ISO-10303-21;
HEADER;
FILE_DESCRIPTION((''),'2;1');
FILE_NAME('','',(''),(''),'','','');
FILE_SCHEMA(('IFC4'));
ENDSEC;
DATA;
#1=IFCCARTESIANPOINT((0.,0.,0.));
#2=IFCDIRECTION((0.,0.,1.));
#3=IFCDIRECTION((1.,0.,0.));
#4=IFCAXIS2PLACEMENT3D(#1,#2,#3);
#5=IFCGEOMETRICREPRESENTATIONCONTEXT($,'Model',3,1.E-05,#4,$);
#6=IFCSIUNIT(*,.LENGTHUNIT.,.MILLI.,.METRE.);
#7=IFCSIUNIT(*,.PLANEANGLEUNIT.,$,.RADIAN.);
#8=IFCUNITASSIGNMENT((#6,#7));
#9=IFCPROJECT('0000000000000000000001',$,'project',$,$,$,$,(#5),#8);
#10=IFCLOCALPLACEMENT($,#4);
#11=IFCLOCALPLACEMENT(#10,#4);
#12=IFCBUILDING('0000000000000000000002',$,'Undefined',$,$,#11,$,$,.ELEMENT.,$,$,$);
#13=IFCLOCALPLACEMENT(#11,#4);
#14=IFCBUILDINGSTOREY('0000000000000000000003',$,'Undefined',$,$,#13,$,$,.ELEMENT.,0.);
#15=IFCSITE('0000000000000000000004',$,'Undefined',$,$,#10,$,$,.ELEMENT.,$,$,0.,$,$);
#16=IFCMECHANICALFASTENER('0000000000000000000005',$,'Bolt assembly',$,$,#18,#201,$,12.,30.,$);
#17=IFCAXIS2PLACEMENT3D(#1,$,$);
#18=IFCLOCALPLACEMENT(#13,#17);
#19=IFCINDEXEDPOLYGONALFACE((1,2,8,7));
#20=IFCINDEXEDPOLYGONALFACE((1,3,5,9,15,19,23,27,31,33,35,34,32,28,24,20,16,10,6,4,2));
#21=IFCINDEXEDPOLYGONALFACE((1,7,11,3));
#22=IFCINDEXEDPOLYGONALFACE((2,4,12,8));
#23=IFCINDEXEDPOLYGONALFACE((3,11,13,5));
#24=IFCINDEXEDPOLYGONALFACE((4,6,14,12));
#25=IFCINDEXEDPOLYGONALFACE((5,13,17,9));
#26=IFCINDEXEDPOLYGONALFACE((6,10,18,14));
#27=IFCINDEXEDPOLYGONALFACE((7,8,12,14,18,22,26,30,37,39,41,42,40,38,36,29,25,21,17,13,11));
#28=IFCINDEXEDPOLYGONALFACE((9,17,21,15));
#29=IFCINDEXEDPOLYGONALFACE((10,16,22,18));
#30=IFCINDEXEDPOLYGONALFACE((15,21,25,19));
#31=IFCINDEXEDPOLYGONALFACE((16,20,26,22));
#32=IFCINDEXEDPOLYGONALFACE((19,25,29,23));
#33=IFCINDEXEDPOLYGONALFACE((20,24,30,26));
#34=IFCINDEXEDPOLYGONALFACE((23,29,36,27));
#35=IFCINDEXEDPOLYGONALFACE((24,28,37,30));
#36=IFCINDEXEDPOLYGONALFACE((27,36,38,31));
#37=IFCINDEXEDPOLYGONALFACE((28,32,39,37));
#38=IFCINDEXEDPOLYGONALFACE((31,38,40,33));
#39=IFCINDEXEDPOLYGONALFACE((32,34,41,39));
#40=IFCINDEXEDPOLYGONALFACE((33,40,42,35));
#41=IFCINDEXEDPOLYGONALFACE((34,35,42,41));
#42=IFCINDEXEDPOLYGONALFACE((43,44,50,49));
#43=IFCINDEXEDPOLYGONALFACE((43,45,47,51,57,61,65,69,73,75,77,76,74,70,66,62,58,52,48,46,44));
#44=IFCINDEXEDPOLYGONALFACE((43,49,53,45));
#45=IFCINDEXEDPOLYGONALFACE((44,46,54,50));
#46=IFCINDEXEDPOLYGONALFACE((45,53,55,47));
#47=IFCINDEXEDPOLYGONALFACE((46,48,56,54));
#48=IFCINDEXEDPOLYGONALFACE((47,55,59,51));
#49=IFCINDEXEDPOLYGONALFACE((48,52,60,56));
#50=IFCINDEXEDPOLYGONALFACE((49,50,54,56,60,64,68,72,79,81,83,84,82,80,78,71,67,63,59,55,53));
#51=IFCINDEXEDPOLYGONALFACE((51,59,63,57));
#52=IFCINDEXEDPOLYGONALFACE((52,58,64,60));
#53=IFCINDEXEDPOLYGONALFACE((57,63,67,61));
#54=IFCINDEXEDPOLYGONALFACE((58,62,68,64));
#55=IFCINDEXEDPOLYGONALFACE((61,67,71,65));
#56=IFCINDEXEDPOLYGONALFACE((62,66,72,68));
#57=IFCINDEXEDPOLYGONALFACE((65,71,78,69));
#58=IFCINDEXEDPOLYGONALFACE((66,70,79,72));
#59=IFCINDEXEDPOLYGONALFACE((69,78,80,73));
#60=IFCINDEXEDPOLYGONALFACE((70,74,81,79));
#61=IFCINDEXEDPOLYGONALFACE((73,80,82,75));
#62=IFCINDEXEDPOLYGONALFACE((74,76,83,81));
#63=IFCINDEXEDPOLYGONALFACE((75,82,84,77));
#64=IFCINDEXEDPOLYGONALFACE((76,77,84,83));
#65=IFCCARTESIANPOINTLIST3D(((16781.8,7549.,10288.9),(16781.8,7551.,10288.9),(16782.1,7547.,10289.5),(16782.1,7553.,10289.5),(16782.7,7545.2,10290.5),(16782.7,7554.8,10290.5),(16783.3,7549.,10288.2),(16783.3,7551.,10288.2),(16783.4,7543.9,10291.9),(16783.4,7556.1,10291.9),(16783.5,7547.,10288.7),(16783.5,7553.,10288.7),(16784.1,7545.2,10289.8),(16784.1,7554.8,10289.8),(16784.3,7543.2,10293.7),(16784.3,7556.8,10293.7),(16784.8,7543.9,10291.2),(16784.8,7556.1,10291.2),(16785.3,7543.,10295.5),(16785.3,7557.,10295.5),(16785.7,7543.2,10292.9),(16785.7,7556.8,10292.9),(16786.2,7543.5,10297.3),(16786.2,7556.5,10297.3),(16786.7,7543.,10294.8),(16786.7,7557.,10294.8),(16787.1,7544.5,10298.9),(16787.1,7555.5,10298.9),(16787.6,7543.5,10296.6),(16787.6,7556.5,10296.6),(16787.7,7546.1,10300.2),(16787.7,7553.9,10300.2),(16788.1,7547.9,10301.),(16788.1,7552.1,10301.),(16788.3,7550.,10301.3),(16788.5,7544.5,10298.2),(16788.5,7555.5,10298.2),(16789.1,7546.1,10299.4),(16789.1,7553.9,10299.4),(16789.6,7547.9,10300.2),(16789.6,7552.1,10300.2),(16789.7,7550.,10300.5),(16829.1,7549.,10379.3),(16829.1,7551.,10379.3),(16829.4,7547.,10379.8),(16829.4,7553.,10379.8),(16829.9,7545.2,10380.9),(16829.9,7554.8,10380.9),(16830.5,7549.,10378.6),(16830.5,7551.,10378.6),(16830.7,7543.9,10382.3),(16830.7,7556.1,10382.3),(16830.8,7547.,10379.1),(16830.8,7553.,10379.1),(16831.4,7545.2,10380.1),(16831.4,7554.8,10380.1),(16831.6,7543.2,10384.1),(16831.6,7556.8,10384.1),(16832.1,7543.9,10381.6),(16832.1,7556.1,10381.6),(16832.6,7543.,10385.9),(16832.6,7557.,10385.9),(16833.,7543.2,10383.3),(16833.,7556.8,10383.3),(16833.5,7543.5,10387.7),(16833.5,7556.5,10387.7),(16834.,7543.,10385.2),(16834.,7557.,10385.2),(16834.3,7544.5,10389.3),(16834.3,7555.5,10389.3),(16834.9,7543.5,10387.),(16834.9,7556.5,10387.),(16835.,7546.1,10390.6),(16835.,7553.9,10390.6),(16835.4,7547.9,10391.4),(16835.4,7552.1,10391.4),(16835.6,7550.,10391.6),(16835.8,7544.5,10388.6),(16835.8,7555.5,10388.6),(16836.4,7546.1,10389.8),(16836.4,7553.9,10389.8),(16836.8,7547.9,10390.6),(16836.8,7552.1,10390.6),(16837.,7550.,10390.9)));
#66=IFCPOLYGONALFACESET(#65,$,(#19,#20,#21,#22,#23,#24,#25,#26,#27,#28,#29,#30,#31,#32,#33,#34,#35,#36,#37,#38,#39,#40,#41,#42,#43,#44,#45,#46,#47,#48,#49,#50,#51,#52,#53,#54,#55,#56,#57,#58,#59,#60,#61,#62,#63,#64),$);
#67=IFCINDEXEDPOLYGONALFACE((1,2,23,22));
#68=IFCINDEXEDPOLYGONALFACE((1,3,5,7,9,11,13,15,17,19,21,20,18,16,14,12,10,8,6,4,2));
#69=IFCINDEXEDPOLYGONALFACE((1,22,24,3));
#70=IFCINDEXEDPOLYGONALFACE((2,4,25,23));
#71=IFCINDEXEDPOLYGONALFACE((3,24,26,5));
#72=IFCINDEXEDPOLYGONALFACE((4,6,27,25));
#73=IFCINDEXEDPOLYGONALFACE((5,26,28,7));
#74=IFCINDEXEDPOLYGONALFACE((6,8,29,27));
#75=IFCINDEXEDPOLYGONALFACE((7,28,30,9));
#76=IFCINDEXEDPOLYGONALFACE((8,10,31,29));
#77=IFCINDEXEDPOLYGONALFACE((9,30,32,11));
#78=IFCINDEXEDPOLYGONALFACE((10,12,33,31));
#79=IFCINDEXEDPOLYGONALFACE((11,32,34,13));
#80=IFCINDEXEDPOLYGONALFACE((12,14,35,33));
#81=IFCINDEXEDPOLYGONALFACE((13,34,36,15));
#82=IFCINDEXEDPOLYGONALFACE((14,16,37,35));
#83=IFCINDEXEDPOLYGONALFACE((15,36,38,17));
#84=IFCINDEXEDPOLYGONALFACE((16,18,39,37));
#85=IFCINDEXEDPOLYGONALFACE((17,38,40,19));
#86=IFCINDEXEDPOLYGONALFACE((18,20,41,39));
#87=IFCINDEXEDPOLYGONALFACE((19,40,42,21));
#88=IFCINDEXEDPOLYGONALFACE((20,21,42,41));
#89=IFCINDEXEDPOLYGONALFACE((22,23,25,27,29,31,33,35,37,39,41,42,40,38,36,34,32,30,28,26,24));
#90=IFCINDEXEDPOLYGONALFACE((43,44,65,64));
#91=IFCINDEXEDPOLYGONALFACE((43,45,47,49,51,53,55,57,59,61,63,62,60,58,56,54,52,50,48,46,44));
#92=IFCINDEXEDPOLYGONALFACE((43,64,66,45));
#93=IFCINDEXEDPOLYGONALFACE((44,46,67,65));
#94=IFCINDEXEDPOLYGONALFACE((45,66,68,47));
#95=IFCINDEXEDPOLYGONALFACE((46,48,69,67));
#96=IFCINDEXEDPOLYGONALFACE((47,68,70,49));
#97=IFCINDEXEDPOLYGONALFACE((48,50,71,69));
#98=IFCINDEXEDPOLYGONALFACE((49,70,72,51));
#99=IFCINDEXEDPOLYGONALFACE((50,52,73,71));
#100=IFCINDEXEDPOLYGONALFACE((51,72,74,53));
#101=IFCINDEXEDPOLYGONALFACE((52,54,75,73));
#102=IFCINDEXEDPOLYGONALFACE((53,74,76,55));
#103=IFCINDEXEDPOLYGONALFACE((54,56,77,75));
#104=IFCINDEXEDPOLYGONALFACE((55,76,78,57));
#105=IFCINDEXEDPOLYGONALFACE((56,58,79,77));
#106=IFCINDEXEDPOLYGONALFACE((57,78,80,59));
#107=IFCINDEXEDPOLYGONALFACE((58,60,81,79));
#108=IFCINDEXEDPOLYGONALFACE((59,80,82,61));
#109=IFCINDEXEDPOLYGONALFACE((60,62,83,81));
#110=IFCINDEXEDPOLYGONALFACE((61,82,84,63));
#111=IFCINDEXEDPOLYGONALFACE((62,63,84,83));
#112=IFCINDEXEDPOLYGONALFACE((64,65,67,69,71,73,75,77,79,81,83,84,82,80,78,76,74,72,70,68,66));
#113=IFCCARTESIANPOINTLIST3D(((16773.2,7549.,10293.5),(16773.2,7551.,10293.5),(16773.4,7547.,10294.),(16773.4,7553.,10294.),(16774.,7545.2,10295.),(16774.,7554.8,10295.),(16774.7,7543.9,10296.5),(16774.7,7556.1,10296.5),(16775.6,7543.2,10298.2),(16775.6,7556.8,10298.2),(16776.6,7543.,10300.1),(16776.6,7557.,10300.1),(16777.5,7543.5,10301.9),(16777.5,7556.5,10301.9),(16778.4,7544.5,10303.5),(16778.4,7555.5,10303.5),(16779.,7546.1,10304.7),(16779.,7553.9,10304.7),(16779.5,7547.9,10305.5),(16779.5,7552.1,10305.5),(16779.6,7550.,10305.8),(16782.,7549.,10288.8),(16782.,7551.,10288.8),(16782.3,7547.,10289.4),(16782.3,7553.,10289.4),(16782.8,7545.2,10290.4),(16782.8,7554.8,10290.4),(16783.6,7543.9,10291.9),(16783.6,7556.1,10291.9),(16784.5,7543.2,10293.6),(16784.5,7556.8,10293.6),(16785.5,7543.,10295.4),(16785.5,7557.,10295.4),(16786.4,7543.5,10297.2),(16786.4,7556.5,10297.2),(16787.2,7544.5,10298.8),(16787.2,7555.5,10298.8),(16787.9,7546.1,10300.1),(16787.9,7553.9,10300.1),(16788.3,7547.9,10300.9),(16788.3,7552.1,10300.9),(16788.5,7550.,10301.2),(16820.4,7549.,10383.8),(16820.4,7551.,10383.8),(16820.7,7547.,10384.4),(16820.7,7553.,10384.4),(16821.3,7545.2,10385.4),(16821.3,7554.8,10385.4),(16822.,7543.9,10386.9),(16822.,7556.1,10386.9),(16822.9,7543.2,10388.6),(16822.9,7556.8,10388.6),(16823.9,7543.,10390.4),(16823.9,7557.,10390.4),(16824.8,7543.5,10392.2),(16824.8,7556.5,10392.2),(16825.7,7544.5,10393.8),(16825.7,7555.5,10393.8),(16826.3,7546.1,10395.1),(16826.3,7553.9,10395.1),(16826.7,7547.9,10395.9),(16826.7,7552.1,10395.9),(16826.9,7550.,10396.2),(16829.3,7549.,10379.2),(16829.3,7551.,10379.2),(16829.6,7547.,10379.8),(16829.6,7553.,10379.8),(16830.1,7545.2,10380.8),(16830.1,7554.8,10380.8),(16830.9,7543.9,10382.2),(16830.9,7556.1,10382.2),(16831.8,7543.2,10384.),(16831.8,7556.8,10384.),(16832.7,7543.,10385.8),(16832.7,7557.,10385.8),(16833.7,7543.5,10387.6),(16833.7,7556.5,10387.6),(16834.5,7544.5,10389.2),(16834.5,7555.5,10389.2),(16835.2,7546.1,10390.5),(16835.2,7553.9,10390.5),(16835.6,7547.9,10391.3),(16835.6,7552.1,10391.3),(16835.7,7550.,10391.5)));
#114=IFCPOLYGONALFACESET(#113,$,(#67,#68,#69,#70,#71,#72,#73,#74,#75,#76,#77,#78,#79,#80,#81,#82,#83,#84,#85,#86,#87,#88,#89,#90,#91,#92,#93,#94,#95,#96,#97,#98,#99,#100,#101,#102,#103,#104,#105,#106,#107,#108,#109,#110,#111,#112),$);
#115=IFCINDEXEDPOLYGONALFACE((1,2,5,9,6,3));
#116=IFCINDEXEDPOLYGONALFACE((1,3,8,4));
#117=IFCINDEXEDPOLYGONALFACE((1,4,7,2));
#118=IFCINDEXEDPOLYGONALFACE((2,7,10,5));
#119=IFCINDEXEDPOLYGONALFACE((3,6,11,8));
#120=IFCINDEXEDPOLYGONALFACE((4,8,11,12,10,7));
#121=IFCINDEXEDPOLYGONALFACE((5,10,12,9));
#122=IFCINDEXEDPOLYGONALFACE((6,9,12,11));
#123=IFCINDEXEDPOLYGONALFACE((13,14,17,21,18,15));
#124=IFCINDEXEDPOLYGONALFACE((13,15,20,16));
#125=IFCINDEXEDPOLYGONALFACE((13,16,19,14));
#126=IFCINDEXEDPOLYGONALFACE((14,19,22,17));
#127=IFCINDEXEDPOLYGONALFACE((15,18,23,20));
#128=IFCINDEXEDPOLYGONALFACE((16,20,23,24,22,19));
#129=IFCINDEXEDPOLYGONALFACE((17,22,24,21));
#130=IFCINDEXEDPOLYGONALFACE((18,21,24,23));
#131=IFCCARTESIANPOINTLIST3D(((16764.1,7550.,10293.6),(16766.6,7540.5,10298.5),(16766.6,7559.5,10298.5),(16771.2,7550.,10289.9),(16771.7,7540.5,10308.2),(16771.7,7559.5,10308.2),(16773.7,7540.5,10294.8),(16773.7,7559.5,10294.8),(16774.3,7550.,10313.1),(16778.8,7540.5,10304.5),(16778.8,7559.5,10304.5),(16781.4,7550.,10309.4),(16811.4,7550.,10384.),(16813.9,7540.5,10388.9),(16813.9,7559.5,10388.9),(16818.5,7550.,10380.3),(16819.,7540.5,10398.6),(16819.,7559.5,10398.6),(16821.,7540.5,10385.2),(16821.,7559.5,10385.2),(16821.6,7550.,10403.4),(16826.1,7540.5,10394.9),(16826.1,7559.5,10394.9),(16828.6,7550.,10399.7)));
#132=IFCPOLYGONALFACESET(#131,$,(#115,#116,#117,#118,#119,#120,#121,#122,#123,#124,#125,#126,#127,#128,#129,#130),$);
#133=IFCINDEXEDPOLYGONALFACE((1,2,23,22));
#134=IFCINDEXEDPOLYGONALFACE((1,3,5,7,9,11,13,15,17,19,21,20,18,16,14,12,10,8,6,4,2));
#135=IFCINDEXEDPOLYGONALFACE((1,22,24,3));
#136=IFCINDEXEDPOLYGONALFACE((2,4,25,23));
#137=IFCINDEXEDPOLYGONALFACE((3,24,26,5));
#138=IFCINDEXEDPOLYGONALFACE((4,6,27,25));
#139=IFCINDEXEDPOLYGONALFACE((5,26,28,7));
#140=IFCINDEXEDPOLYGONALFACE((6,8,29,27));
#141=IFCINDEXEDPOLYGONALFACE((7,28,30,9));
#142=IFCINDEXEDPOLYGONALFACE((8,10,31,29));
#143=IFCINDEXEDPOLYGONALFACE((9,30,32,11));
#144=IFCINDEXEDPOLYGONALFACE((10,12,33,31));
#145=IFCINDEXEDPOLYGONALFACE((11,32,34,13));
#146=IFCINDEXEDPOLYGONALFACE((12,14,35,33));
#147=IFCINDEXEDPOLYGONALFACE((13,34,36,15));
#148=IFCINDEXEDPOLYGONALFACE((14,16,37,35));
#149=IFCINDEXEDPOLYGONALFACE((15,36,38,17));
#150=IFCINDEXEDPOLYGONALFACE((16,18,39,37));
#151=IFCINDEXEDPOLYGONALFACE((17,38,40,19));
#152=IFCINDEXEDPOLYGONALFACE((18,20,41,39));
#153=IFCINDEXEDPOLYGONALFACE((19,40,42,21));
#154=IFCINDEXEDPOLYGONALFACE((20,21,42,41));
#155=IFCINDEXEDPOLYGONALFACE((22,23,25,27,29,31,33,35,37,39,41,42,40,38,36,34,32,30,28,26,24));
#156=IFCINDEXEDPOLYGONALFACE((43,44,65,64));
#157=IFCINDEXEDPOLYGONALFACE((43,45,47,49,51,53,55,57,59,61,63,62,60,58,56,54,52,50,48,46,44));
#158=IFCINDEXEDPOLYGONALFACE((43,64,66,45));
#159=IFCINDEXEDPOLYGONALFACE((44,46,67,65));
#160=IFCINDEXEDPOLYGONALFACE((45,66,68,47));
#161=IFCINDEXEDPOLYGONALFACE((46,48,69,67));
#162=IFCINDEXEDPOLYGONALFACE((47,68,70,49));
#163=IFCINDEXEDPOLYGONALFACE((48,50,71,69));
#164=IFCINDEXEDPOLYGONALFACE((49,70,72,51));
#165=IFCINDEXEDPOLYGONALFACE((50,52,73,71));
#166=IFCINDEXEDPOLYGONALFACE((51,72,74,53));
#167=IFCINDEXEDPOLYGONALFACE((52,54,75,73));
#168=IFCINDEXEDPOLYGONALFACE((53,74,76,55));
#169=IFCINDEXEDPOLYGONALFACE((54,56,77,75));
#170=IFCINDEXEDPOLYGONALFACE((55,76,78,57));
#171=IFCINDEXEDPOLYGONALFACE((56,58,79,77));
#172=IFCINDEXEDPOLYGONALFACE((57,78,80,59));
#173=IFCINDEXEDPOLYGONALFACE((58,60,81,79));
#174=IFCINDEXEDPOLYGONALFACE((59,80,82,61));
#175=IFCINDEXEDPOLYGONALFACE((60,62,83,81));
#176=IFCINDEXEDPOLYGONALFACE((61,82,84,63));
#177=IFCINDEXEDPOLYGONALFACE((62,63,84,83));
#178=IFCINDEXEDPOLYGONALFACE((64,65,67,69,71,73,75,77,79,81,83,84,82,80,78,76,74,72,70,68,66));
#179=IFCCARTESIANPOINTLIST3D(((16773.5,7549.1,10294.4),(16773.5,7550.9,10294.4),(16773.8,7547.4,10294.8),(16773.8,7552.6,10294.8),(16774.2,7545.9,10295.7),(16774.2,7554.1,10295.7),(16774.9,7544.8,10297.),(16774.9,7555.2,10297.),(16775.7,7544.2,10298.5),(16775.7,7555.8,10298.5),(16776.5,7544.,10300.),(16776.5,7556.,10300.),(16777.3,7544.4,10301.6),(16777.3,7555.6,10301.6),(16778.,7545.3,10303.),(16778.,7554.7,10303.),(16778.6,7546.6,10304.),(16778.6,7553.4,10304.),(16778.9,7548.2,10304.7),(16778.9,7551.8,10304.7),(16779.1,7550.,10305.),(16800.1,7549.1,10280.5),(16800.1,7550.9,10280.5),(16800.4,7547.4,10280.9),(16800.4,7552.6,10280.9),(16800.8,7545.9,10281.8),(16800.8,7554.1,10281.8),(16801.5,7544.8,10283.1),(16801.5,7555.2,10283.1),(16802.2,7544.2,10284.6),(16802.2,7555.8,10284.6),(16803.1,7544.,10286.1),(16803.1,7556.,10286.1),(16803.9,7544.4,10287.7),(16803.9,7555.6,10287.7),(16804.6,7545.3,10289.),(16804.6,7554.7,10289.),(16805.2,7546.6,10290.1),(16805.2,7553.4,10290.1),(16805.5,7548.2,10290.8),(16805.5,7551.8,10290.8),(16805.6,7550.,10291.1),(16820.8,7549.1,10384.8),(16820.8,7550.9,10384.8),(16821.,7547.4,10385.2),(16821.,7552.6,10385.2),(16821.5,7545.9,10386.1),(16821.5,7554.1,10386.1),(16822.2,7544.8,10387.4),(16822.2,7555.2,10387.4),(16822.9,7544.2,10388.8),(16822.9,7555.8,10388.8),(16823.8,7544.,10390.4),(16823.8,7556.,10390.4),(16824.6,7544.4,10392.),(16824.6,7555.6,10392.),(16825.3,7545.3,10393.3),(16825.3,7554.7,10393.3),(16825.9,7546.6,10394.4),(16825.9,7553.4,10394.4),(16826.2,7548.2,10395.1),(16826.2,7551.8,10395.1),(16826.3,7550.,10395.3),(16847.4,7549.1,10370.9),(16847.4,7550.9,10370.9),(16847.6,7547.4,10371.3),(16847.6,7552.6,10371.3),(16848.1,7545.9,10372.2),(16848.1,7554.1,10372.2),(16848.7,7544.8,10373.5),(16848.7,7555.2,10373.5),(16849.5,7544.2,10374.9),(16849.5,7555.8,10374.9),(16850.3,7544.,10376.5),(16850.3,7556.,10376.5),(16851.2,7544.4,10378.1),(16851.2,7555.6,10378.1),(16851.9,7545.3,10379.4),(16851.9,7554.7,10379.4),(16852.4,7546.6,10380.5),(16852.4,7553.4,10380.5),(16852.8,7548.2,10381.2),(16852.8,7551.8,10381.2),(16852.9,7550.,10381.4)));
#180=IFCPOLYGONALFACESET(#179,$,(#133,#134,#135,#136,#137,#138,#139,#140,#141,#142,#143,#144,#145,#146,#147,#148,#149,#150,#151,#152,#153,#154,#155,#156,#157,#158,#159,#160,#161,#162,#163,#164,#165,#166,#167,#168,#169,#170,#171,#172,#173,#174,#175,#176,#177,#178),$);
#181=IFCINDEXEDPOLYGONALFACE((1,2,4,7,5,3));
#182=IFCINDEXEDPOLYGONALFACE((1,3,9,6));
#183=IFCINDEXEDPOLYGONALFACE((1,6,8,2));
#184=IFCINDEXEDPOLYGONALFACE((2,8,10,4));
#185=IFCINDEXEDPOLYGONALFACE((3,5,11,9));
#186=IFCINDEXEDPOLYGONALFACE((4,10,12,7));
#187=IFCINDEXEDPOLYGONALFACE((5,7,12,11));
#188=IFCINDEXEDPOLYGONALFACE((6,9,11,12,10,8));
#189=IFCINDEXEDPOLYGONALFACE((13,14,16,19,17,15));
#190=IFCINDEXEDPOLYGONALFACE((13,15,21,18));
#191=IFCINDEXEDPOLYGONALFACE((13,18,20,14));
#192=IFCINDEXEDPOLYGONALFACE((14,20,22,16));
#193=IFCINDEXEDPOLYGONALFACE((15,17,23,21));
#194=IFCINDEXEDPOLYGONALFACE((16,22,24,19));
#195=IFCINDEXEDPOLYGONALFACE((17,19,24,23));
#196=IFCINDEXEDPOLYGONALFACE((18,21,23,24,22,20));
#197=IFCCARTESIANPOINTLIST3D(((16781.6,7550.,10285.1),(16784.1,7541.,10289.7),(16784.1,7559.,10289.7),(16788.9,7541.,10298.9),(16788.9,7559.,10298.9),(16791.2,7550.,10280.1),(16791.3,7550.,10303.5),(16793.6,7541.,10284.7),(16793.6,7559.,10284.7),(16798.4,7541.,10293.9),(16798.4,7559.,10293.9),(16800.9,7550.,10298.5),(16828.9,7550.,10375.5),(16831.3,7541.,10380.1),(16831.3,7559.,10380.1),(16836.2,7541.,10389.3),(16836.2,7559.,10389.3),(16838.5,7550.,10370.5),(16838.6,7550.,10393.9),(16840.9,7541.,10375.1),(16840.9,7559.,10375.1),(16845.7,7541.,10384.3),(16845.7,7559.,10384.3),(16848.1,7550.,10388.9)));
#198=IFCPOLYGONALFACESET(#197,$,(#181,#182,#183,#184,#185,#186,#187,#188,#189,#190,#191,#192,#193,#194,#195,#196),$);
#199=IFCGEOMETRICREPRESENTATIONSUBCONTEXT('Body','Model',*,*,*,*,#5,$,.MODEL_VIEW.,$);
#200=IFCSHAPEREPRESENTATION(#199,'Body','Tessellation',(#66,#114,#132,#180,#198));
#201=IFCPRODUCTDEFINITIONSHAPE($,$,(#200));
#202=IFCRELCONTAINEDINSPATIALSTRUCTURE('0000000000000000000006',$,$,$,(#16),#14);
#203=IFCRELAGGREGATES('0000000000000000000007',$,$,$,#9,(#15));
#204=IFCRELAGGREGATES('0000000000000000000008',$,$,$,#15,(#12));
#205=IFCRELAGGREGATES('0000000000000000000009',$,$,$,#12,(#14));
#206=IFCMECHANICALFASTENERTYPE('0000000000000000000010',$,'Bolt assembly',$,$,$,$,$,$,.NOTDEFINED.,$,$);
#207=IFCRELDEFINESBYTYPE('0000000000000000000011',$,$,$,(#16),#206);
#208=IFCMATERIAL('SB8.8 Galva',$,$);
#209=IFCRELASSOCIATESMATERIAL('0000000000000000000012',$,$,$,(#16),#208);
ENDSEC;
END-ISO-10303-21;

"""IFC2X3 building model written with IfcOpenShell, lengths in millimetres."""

from ifc_helpers import new_model, si_unit, frame, origin_with_axes, origin_2d_with_axis, place, context, subcontext, project, spatial, polyline, circle, outline, extrude, source, transform, mapped, material, type_object, element, save


model = new_model("IFC2X3")

# Units and contexts
model_context = context("Model", 3, precision=1e-05, world=origin_with_axes())
body_context = subcontext(model_context, "Body", "Model", "MODEL_VIEW")
ifc_project = project(units=[si_unit("LENGTHUNIT", "METRE", prefix="MILLI"), si_unit("PLANEANGLEUNIT", "RADIAN")], contexts=[model_context])

# Site, building, storey
site_placement = place(None, origin_with_axes())
site = spatial("IfcSite", under=ifc_project, at=site_placement, Name="Undefined", CompositionType="ELEMENT", RefElevation=0.0)
building_placement = place(site_placement, origin_with_axes())
building = spatial("IfcBuilding", under=site, at=building_placement, Name="Undefined", CompositionType="ELEMENT")
storey_placement = place(building_placement, origin_with_axes())
storey = spatial("IfcBuildingStorey", under=building, at=storey_placement, Name="Undefined", CompositionType="ELEMENT", Elevation=0.0)

# Mechanical fastener
mechanical_fastener_type = type_object("IfcMechanicalFastenerType", Name="Bolt assembly")
ifc_material_1 = material(Name="SB8.8 Galva")
shared_shape_1 = source(origin_with_axes(), body_context, "Body", "SweptSolid", [
    extrude(circle(Radius=7.0, at=origin_2d_with_axis()), frame((0.0, -0.1, 0.0), z_axis=(0.0, 1.0, 0.0), x_axis=(1.0, 0.0, 0.0)), (0.0, 0.0, 1.0), 1.6),
    extrude(circle(Radius=7.0, at=origin_2d_with_axis()), frame((0.0, -9.9, 0.0), z_axis=(0.0, 1.0, 0.0), x_axis=(1.0, 0.0, 0.0)), (0.0, 0.0, 1.0), 10.0),
    extrude(outline(polyline([(11.0, 0.0), (5.5, 9.5), (-5.5, 9.5), (-11.0, 0.0), (-5.5, -9.5), (5.5, -9.5), (11.0, 0.0)])), frame((0.0, -18.0, 0.0), z_axis=(0.0, 1.0, 0.0), x_axis=(1.0, 0.0, 0.0)), (0.0, 0.0, 1.0), 8.0),
    extrude(circle(Radius=6.0, at=origin_2d_with_axis()), frame((0.0, -10.0, 0.0), z_axis=(0.0, 1.0, 0.0), x_axis=(1.0, 0.0, 0.0)), (0.0, 0.0, 1.0), 30.0),
    extrude(outline(polyline([(10.4, 0.0), (5.2, 9.0), (-5.2, 9.0), (-10.4, 0.0), (-5.2, -9.0), (5.2, -9.0), (10.4, 0.0)])), frame((0.0, 1.5, 0.0), z_axis=(0.0, 1.0, 0.0), x_axis=(1.0, 0.0, 0.0)), (0.0, 0.0, 1.0), 10.8),
])
for number, where, z_axis, x_axis, name in (
    (1, (16785.1, 7550.0, 10295.0), (0.0, 1.0, 0.0), (0.463529, 0.0, 0.886082), "Bolt assembly"),
):
    element("IfcMechanicalFastener", number, at=place(storey_placement, frame(where, z_axis=z_axis, x_axis=x_axis)), inside=storey, type_object=mechanical_fastener_type, material=ifc_material_1, Name=name, NominalDiameter=12.0, NominalLength=30.0, context=body_context, shape_type="MappedRepresentation", body=[
        mapped(shared_shape_1, transform((0.0, 0.0, 0.0))),
        mapped(shared_shape_1, transform((102.0, 0.0, 0.0))),
    ])

save(model, "model.ifc")
